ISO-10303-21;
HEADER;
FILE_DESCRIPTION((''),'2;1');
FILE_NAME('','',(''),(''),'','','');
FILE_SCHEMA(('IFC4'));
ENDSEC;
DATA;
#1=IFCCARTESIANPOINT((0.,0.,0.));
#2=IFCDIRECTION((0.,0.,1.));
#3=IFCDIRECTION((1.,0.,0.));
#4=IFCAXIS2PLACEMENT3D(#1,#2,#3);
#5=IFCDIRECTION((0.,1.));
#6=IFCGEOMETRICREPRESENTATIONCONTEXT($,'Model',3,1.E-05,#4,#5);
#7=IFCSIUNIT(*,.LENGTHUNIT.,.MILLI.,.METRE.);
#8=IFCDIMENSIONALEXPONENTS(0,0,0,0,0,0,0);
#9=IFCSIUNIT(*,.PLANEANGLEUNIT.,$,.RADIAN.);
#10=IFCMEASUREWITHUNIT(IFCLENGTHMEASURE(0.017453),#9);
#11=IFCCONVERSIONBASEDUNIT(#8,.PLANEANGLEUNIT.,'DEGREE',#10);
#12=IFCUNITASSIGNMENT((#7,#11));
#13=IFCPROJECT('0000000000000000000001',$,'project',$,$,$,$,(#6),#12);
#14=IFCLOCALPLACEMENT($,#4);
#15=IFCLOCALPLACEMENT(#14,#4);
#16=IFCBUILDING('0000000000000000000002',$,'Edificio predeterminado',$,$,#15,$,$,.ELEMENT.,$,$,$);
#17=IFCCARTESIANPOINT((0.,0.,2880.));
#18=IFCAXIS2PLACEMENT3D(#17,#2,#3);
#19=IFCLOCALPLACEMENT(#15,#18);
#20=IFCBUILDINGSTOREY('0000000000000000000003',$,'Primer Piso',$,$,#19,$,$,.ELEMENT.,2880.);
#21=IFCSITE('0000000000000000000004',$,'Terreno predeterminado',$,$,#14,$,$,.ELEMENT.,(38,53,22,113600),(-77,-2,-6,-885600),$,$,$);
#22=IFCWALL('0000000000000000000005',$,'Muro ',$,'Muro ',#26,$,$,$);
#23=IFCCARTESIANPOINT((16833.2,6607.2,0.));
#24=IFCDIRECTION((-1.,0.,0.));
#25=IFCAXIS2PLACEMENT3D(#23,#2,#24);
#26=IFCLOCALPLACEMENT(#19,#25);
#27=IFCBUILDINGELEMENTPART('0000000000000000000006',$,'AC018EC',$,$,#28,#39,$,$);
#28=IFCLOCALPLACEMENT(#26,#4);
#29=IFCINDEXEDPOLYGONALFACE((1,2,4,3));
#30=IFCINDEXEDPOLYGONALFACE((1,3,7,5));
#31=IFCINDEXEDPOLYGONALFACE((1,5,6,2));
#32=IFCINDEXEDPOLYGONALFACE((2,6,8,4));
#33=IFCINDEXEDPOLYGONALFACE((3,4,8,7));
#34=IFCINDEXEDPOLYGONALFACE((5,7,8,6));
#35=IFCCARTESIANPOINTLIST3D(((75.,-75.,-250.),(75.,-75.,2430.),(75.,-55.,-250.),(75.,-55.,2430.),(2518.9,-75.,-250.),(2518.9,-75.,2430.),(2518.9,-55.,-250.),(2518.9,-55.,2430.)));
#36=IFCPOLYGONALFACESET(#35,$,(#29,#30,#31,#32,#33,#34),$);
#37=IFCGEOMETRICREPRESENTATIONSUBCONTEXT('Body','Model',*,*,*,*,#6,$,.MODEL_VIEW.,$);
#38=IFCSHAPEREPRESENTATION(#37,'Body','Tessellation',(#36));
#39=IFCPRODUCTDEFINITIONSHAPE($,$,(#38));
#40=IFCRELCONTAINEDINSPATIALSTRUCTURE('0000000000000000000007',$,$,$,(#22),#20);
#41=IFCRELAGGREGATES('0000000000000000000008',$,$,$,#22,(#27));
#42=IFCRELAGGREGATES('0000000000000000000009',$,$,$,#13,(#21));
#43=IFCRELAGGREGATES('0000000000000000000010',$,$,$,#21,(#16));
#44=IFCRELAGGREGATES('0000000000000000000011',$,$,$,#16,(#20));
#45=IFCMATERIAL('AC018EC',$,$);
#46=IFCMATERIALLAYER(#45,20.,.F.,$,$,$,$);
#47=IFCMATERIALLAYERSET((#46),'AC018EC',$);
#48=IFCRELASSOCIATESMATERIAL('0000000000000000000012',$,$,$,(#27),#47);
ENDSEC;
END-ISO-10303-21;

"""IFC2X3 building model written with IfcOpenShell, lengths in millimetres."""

from ifc_helpers import new_model, entity, si_unit, converted_unit, direction, frame, origin_with_axes, place, context, subcontext, project, spatial, polyline, outline, extrude, material, layer, layer_set, layer_usage, element, aggregate, save


model = new_model("IFC2X3")

# Units and contexts
model_context = context("Model", 3, precision=1e-05, world=origin_with_axes(), true_north=direction((0.0, 1.0)))
body_context = subcontext(model_context, "Body", "Model", "MODEL_VIEW")
ifc_project = project(units=[si_unit("LENGTHUNIT", "METRE", prefix="MILLI"), converted_unit("PLANEANGLEUNIT", "DEGREE", entity("IfcLengthMeasure", 0.017453), si_unit("PLANEANGLEUNIT", "RADIAN"), dimensions=[0, 0, 0, 0, 0, 0, 0])], contexts=[model_context])

# Site, building, storey
site_placement = place(None, origin_with_axes())
site = spatial("IfcSite", under=ifc_project, at=site_placement, Name="Terreno predeterminado", CompositionType="ELEMENT", RefLatitude=(38, 53, 22, 113600), RefLongitude=(-77, -2, -6, -885600))
building_placement = place(site_placement, origin_with_axes())
building = spatial("IfcBuilding", under=site, at=building_placement, Name="Edificio predeterminado", CompositionType="ELEMENT")
storey_placement = place(building_placement, frame((0.0, 0.0, 2880.0), z_axis=(0.0, 0.0, 1.0), x_axis=(1.0, 0.0, 0.0)))
storey = spatial("IfcBuildingStorey", under=building, at=storey_placement, Name="Primer Piso", CompositionType="ELEMENT", Elevation=2880.0)

# Wall, building element part
wall_1_placement = place(storey_placement, frame((16833.2, 6607.2, 0.0), z_axis=(0.0, 0.0, 1.0), x_axis=(-1.0, 0.0, 0.0)))
wall_1 = element("IfcWall", 1, at=wall_1_placement, inside=storey, Name="Muro ", ObjectType="Muro ")
ifc_material_1 = material(Name="AC018EC")
ifc_layer_1 = layer(ifc_material_1, 20.0, ventilated=False)
ifc_layer_set_1 = layer_set([ifc_layer_1], Name="AC018EC")
ifc_layer_usage_1 = layer_usage(ifc_layer_set_1, "AXIS2", "NEGATIVE", 55.0)
building_element_part_1_placement = place(wall_1_placement, origin_with_axes())
building_element_part_1 = element("IfcBuildingElementPart", 2, at=building_element_part_1_placement, material=ifc_layer_usage_1, Name="AC018EC", context=body_context, shape_type="SweptSolid", body=[
    extrude(outline(polyline([(2518.9, -55.0), (2518.9, -75.0), (75.0, -75.0), (75.0, -55.0), (2518.9, -55.0)])), frame((0.0, 0.0, -250.0), z_axis=(0.0, 0.0, 1.0), x_axis=(1.0, 0.0, 0.0)), (0.0, 0.0, 1.0), 2680.0),
])
aggregate(wall_1, [building_element_part_1])

save(model, "model.ifc")
